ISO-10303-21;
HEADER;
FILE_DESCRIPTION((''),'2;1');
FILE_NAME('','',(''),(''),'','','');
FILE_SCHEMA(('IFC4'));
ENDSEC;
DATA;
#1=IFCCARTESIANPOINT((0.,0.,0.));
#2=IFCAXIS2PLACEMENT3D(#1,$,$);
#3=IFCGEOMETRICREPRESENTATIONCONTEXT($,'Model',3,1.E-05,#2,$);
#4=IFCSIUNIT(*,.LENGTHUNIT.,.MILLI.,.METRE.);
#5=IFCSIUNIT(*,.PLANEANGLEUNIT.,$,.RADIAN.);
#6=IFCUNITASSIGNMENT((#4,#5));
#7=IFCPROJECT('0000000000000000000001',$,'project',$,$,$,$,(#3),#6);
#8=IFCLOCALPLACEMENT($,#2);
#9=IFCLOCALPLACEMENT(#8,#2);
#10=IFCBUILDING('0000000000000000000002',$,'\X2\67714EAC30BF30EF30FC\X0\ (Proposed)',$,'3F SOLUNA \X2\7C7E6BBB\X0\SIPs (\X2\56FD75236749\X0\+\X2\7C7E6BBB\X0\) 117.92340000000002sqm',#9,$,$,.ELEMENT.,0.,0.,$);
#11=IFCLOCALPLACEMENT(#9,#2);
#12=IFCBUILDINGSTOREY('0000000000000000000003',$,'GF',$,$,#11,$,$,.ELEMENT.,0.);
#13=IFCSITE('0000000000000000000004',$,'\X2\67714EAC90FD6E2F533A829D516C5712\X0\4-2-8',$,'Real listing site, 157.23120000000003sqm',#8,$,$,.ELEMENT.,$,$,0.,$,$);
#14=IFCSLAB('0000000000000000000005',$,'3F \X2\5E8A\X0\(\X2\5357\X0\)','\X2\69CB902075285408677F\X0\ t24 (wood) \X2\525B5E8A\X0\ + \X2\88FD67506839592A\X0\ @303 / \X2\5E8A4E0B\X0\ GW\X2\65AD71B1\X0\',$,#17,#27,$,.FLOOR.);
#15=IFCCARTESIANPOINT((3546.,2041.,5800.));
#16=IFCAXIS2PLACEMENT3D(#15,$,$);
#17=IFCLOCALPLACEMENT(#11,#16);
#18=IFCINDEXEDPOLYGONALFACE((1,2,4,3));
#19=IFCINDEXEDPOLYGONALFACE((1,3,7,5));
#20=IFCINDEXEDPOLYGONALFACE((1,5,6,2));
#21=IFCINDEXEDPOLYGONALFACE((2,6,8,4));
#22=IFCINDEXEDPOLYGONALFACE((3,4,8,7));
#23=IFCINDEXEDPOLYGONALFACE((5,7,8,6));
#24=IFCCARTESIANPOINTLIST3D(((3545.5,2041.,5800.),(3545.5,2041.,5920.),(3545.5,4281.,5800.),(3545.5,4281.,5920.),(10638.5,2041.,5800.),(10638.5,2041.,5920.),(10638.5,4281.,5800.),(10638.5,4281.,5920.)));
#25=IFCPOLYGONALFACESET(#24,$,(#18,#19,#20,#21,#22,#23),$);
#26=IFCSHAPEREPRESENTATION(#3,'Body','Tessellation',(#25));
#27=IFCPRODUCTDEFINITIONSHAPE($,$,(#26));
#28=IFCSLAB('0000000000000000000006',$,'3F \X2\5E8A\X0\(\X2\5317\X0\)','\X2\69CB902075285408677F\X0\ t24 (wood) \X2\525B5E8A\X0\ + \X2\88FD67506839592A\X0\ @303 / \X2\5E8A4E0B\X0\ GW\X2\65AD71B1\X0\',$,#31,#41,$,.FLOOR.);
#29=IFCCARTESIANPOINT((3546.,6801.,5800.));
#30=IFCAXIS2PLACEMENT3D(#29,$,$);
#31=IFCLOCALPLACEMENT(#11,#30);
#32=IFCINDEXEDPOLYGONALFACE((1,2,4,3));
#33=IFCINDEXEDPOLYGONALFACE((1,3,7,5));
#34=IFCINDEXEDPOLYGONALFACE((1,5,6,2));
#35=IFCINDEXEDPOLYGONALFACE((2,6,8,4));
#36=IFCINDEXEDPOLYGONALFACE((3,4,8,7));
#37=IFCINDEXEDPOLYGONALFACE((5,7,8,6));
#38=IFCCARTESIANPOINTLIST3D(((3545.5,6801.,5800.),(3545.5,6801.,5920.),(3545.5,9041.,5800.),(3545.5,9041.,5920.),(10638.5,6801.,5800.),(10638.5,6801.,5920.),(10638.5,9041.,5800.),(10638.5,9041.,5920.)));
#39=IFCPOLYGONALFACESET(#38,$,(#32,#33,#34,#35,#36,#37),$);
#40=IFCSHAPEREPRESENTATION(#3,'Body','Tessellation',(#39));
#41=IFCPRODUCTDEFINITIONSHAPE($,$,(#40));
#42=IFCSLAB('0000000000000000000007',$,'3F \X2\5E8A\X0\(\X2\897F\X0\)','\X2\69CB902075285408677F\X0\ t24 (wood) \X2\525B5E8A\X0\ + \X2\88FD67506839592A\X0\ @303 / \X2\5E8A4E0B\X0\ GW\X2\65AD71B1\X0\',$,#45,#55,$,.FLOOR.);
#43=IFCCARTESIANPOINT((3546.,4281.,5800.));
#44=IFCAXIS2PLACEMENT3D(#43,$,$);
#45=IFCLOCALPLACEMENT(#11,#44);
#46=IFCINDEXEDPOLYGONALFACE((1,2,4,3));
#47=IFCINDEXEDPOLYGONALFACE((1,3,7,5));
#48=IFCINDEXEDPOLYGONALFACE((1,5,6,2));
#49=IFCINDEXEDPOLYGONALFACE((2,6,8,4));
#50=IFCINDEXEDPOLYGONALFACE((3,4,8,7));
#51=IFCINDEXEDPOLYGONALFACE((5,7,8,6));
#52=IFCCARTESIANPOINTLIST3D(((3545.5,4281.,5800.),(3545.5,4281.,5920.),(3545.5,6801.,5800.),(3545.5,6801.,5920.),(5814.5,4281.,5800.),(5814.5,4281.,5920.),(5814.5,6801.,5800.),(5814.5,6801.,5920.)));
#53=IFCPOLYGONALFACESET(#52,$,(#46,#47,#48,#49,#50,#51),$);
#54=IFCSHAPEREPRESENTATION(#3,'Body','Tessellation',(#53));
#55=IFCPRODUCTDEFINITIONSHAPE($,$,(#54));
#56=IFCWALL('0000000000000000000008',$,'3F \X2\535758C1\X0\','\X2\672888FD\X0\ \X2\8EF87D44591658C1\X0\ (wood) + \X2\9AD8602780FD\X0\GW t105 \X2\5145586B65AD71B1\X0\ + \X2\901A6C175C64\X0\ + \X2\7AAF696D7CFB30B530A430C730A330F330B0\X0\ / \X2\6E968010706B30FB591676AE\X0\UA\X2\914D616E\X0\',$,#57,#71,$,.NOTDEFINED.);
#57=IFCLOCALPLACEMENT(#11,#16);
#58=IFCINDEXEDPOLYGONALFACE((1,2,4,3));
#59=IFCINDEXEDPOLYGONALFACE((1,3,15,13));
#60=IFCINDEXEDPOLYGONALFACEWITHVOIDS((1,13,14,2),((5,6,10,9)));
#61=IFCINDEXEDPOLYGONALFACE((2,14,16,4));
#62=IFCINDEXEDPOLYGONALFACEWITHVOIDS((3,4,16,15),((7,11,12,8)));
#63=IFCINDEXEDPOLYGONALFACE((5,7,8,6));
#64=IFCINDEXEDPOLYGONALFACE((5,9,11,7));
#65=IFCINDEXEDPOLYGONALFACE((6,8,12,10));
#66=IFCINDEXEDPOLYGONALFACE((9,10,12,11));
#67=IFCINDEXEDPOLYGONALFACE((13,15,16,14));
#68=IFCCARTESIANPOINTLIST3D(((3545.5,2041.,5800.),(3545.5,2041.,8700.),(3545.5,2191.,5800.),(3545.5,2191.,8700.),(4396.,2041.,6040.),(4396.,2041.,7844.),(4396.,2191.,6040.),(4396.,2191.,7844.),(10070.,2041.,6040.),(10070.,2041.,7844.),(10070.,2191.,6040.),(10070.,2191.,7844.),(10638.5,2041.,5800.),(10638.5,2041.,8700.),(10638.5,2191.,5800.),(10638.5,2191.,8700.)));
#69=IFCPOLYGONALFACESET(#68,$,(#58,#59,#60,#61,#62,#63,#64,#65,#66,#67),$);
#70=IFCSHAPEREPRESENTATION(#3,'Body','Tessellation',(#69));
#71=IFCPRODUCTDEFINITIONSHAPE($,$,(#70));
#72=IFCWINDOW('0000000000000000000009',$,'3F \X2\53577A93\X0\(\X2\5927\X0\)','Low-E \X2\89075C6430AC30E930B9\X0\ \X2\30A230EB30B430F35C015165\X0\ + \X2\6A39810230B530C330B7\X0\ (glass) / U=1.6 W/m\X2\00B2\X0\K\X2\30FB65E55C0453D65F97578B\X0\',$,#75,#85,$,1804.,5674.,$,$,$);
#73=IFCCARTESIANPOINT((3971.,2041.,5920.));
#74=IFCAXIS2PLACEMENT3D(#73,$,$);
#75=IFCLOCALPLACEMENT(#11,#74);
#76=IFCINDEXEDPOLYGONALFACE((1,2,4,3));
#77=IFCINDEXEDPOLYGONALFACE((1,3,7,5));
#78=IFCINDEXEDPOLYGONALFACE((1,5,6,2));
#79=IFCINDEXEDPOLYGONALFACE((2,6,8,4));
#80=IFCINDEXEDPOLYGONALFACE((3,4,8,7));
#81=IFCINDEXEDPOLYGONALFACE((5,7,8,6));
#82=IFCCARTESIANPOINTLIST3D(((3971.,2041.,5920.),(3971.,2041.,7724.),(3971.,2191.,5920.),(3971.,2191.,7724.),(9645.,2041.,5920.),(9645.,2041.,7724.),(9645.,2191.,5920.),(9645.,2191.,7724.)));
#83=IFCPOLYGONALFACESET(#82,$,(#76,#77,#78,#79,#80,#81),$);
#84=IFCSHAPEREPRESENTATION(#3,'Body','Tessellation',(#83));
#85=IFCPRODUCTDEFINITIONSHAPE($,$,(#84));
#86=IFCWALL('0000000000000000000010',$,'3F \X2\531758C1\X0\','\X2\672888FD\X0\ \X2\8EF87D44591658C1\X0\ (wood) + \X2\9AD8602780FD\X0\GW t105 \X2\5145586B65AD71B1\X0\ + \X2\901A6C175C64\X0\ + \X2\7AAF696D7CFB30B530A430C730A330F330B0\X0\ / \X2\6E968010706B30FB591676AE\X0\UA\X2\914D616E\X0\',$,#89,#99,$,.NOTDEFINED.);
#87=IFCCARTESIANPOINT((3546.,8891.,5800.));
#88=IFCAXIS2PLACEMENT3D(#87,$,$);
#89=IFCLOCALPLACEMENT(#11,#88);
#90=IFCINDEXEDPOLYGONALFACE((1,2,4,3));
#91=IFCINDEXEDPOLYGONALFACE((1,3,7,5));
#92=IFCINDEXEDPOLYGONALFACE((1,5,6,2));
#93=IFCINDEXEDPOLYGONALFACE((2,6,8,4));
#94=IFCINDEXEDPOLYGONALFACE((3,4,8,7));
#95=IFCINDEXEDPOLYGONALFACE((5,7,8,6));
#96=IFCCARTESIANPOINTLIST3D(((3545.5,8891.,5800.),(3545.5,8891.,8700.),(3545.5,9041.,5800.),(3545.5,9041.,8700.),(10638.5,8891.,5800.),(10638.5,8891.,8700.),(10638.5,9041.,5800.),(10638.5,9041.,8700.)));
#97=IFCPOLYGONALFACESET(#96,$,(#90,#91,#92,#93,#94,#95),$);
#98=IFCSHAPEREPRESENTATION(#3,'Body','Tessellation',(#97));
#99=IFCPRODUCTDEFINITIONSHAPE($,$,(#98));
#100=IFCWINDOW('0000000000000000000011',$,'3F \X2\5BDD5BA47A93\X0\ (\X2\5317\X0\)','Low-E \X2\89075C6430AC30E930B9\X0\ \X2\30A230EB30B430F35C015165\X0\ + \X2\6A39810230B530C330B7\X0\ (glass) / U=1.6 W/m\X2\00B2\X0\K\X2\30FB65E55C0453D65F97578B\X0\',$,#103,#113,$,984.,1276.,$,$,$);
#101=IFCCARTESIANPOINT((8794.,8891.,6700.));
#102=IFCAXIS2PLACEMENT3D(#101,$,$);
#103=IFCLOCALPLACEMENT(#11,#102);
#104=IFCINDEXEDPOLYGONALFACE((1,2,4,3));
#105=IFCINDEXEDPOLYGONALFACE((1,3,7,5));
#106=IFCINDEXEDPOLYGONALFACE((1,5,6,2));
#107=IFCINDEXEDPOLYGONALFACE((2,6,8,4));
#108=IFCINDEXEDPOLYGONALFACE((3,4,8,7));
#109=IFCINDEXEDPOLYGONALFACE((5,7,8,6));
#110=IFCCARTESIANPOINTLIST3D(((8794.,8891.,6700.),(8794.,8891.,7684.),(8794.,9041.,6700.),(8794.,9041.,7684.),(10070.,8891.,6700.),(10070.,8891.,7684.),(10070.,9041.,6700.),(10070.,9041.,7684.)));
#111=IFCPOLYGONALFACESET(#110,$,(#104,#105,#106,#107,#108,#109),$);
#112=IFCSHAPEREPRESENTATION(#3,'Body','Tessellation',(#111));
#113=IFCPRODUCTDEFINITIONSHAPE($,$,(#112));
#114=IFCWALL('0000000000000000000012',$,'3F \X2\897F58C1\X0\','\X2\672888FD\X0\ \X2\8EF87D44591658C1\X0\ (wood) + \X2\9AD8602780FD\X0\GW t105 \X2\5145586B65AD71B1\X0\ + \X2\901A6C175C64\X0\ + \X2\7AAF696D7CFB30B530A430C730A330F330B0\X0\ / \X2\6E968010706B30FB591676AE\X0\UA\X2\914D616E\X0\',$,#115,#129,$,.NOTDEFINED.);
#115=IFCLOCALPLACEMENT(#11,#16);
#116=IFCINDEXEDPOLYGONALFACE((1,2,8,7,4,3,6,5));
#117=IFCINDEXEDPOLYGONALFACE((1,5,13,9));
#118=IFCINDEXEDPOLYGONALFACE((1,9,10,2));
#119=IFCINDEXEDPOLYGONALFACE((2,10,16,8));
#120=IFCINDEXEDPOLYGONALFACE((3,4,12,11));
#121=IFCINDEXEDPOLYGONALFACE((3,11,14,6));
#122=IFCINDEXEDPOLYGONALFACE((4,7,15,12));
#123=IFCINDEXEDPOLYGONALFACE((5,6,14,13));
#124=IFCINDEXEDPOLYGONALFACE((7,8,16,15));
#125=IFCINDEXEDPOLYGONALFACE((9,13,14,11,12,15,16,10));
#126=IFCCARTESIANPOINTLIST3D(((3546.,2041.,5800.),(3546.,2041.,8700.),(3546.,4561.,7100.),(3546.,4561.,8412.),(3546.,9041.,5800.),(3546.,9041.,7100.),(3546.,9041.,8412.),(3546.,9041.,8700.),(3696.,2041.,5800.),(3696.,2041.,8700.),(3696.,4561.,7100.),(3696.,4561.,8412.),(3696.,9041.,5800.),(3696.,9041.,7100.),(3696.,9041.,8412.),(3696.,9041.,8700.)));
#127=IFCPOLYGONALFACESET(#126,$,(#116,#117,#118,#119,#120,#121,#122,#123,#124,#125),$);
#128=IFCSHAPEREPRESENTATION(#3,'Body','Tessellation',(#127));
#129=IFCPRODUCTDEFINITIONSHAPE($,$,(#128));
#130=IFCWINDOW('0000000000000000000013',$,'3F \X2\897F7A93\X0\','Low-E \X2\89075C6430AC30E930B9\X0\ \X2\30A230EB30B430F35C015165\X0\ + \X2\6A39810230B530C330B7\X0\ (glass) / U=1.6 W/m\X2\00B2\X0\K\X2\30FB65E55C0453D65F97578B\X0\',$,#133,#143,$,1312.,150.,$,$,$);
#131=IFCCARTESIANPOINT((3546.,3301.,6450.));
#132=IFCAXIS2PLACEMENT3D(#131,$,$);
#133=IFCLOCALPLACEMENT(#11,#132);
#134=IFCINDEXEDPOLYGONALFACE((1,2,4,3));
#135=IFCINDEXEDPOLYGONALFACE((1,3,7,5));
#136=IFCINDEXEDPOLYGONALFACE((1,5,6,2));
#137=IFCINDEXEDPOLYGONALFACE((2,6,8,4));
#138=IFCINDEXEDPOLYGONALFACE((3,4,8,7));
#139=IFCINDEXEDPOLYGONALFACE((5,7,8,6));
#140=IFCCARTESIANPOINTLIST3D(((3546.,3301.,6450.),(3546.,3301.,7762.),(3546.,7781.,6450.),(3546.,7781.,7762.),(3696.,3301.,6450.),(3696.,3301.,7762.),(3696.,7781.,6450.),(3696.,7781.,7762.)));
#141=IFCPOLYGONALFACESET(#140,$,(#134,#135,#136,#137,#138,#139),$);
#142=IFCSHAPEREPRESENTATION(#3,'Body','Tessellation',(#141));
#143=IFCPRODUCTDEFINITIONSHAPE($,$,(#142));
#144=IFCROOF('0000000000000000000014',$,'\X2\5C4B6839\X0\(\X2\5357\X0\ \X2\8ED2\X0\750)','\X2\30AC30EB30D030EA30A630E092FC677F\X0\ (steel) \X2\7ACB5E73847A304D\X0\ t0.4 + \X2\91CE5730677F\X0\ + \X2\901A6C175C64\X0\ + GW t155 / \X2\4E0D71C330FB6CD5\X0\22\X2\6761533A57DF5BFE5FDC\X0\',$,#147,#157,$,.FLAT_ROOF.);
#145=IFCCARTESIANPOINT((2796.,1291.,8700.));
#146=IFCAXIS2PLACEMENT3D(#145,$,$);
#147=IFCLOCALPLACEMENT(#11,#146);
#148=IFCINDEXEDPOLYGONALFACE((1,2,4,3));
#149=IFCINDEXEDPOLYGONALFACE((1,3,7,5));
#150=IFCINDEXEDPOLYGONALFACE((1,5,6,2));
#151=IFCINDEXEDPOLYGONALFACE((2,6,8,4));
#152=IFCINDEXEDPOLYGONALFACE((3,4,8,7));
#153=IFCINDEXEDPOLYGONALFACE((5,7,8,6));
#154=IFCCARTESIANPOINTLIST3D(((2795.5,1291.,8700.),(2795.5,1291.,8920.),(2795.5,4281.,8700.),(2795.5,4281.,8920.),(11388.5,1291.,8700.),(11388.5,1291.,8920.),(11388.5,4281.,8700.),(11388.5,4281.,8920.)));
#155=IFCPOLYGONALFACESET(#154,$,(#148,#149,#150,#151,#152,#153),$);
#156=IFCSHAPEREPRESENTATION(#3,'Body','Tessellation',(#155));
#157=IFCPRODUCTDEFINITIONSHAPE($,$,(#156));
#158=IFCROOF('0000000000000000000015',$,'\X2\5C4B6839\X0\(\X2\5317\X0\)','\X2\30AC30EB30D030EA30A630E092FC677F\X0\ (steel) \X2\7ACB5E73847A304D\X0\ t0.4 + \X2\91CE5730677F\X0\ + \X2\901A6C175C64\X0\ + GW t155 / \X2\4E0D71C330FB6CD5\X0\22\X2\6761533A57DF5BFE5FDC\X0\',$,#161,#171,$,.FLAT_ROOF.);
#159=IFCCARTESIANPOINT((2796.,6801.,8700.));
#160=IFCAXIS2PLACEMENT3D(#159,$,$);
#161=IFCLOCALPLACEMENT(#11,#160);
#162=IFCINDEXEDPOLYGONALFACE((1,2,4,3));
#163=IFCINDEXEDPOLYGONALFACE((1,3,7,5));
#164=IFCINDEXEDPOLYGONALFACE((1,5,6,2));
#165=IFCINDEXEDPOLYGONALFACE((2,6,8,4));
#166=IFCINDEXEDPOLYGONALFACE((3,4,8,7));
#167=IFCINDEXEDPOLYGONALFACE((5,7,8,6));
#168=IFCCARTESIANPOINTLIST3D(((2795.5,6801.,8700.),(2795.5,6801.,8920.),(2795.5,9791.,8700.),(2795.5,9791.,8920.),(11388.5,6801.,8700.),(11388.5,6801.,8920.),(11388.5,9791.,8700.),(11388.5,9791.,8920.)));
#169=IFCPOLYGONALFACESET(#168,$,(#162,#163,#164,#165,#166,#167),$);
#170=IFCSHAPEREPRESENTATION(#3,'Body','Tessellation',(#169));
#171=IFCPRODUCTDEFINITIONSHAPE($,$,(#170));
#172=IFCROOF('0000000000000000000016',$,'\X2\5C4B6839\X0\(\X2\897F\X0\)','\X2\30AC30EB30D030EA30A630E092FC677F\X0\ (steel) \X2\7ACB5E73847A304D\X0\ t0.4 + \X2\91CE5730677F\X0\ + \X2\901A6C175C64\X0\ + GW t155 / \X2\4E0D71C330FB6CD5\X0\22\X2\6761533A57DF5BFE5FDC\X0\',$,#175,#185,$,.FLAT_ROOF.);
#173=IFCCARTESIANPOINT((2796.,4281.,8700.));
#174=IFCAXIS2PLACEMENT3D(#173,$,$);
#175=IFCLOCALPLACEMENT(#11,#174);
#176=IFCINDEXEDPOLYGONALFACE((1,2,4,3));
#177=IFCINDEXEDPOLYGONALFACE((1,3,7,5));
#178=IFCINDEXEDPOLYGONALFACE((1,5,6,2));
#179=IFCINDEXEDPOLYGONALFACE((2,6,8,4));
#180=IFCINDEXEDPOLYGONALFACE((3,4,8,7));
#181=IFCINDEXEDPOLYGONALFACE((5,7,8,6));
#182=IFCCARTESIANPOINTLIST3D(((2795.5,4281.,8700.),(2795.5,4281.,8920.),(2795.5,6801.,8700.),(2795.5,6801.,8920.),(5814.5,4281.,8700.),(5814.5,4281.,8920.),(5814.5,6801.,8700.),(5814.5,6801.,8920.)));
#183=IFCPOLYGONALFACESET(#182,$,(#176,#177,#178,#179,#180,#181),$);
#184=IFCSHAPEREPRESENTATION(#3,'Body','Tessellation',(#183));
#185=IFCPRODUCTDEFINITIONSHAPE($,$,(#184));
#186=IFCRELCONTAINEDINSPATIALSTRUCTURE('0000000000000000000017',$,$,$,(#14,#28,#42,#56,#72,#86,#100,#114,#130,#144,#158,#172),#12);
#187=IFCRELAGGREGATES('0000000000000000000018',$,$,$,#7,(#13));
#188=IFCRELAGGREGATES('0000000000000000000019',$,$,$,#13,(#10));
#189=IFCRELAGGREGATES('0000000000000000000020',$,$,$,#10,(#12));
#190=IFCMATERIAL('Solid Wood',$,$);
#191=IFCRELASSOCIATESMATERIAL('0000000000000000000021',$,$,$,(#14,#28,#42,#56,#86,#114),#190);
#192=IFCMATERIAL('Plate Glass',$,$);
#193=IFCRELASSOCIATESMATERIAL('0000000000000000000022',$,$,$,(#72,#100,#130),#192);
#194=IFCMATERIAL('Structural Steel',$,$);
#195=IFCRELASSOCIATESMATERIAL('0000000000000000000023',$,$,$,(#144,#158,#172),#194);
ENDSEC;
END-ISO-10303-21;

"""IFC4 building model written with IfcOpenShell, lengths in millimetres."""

from ifc_helpers import new_model, si_unit, frame, frame_2d, origin, place, context, project, spatial, rectangle, extrude, material, element, fill, save


model = new_model("IFC4")

# Units and contexts
model_context = context("Model", 3, precision=1e-05, world=origin())
ifc_project = project(units=[si_unit("LENGTHUNIT", "METRE", prefix="MILLI"), si_unit("PLANEANGLEUNIT", "RADIAN")], contexts=[model_context])

# Site, building, storey
site_placement = place(None, origin())
site = spatial("IfcSite", under=ifc_project, at=site_placement, Name="東京都港区芝公園4-2-8", ObjectType="Real listing site, 157.23120000000003sqm", CompositionType="ELEMENT", RefElevation=0.0)
building_placement = place(site_placement, origin())
building = spatial("IfcBuilding", under=site, at=building_placement, Name="東京タワー (Proposed)", ObjectType="3F SOLUNA 籾殻SIPs (国産杉+籾殻) 117.92340000000002sqm", CompositionType="ELEMENT", ElevationOfRefHeight=0.0, ElevationOfTerrain=0.0)
storey_placement = place(building_placement, origin())
storey = spatial("IfcBuildingStorey", under=building, at=storey_placement, Name="GF", CompositionType="ELEMENT", Elevation=0.0)

# Slabs
ifc_material_1 = material(Name="Solid Wood")
slab_1_placement = place(storey_placement, frame((3546.0, 2041.0, 5800.0)))
element("IfcSlab", 1, at=slab_1_placement, inside=storey, material=ifc_material_1, Name="3F 床(南)", Description="構造用合板 t24 (wood) 剛床 + 製材根太 @303 / 床下 GW断熱", PredefinedType="FLOOR", context=model_context, shape_type="SweptSolid", body=[
    extrude(rectangle(XDim=7093.0, YDim=2240.0, at=frame_2d((3546.0, 1120.0))), frame((3546.0, 2041.0, 5800.0)), (0.0, 0.0, 1.0), 120.0),
])
slab_2_placement = place(storey_placement, frame((3546.0, 6801.0, 5800.0)))
element("IfcSlab", 2, at=slab_2_placement, inside=storey, material=ifc_material_1, Name="3F 床(北)", Description="構造用合板 t24 (wood) 剛床 + 製材根太 @303 / 床下 GW断熱", PredefinedType="FLOOR", context=model_context, shape_type="SweptSolid", body=[
    extrude(rectangle(XDim=7093.0, YDim=2240.0, at=frame_2d((3546.0, 1120.0))), frame((3546.0, 6801.0, 5800.0)), (0.0, 0.0, 1.0), 120.0),
])
slab_3_placement = place(storey_placement, frame((3546.0, 4281.0, 5800.0)))
element("IfcSlab", 3, at=slab_3_placement, inside=storey, material=ifc_material_1, Name="3F 床(西)", Description="構造用合板 t24 (wood) 剛床 + 製材根太 @303 / 床下 GW断熱", PredefinedType="FLOOR", context=model_context, shape_type="SweptSolid", body=[
    extrude(rectangle(XDim=2269.0, YDim=2520.0, at=frame_2d((1134.0, 1260.0))), frame((3546.0, 4281.0, 5800.0)), (0.0, 0.0, 1.0), 120.0),
])

# Walls, openings, windows
wall_1_placement = place(storey_placement, frame((3546.0, 2041.0, 5800.0)))
wall_1 = element("IfcWall", 4, at=wall_1_placement, inside=storey, material=ifc_material_1, Name="3F 南壁", Description="木製 軸組外壁 (wood) + 高性能GW t105 充填断熱 + 通気層 + 窯業系サイディング / 準耐火・外皮UA配慮", PredefinedType="NOTDEFINED", context=model_context, shape_type="SweptSolid", body=[
    extrude(rectangle(XDim=7093.0, YDim=150.0, at=frame_2d((3546.0, 75.0))), frame((3546.0, 2041.0, 5800.0)), (0.0, 0.0, 1.0), 2900.0),
])
opening_1_placement = place(storey_placement, frame((3971.0, 2041.0, 5920.0)))
opening_1 = element("IfcOpeningElement", 5, at=opening_1_placement, cuts=wall_1, PredefinedType="NOTDEFINED", context=model_context, shape_type="SweptSolid", body=[
    extrude(rectangle(XDim=5674.0, YDim=150.0, at=frame_2d((2837.0, 75.0))), frame((3971.0, 2041.0, 5920.0)), (0.0, 0.0, 1.0), 1804.0),
])
ifc_material_2 = material(Name="Plate Glass")
window_1_placement = place(storey_placement, frame((3971.0, 2041.0, 5920.0)))
window_1 = element("IfcWindow", 6, at=window_1_placement, inside=storey, material=ifc_material_2, Name="3F 南窓(大)", Description="Low-E 複層ガラス アルゴン封入 + 樹脂サッシ (glass) / U=1.6 W/m²K・日射取得型", OverallHeight=1804.0, OverallWidth=5674.0, context=model_context, shape_type="SweptSolid", body=[
    extrude(rectangle(XDim=5674.0, YDim=150.0, at=frame_2d((2837.0, 75.0))), frame((3971.0, 2041.0, 5920.0)), (0.0, 0.0, 1.0), 1804.0),
])
fill(opening_1, window_1)
wall_2_placement = place(storey_placement, frame((3546.0, 8891.0, 5800.0)))
wall_2 = element("IfcWall", 7, at=wall_2_placement, inside=storey, material=ifc_material_1, Name="3F 北壁", Description="木製 軸組外壁 (wood) + 高性能GW t105 充填断熱 + 通気層 + 窯業系サイディング / 準耐火・外皮UA配慮", PredefinedType="NOTDEFINED", context=model_context, shape_type="SweptSolid", body=[
    extrude(rectangle(XDim=7093.0, YDim=150.0, at=frame_2d((3546.0, 75.0))), frame((3546.0, 8891.0, 5800.0)), (0.0, 0.0, 1.0), 2900.0),
])
opening_2_placement = place(storey_placement, frame((8794.0, 8891.0, 6700.0)))
opening_2 = element("IfcOpeningElement", 8, at=opening_2_placement, cuts=wall_2, PredefinedType="NOTDEFINED", context=model_context, shape_type="SweptSolid", body=[
    extrude(rectangle(XDim=1276.0, YDim=150.0, at=frame_2d((638.0, 75.0))), frame((8794.0, 8891.0, 6700.0)), (0.0, 0.0, 1.0), 984.0),
])
window_2_placement = place(storey_placement, frame((8794.0, 8891.0, 6700.0)))
window_2 = element("IfcWindow", 9, at=window_2_placement, inside=storey, material=ifc_material_2, Name="3F 寝室窓 (北)", Description="Low-E 複層ガラス アルゴン封入 + 樹脂サッシ (glass) / U=1.6 W/m²K・日射取得型", OverallHeight=984.0, OverallWidth=1276.0, context=model_context, shape_type="SweptSolid", body=[
    extrude(rectangle(XDim=1276.0, YDim=150.0, at=frame_2d((638.0, 75.0))), frame((8794.0, 8891.0, 6700.0)), (0.0, 0.0, 1.0), 984.0),
])
fill(opening_2, window_2)
wall_3_placement = place(storey_placement, frame((3546.0, 2041.0, 5800.0)))
wall_3 = element("IfcWall", 10, at=wall_3_placement, inside=storey, material=ifc_material_1, Name="3F 西壁", Description="木製 軸組外壁 (wood) + 高性能GW t105 充填断熱 + 通気層 + 窯業系サイディング / 準耐火・外皮UA配慮", PredefinedType="NOTDEFINED", context=model_context, shape_type="SweptSolid", body=[
    extrude(rectangle(XDim=150.0, YDim=7000.0, at=frame_2d((75.0, 3500.0))), frame((3546.0, 2041.0, 5800.0)), (0.0, 0.0, 1.0), 2900.0),
])
opening_3_placement = place(storey_placement, frame((3546.0, 3301.0, 6450.0)))
opening_3 = element("IfcOpeningElement", 11, at=opening_3_placement, cuts=wall_3, PredefinedType="NOTDEFINED", context=model_context, shape_type="SweptSolid", body=[
    extrude(rectangle(XDim=150.0, YDim=4480.0, at=frame_2d((75.0, 2240.0))), frame((3546.0, 3301.0, 6450.0)), (0.0, 0.0, 1.0), 1312.0),
])
window_3_placement = place(storey_placement, frame((3546.0, 3301.0, 6450.0)))
window_3 = element("IfcWindow", 12, at=window_3_placement, inside=storey, material=ifc_material_2, Name="3F 西窓", Description="Low-E 複層ガラス アルゴン封入 + 樹脂サッシ (glass) / U=1.6 W/m²K・日射取得型", OverallHeight=1312.0, OverallWidth=150.0, context=model_context, shape_type="SweptSolid", body=[
    extrude(rectangle(XDim=150.0, YDim=4480.0, at=frame_2d((75.0, 2240.0))), frame((3546.0, 3301.0, 6450.0)), (0.0, 0.0, 1.0), 1312.0),
])
fill(opening_3, window_3)

# Roofs
ifc_material_3 = material(Name="Structural Steel")
roof_1_placement = place(storey_placement, frame((2796.0, 1291.0, 8700.0)))
element("IfcRoof", 13, at=roof_1_placement, inside=storey, material=ifc_material_3, Name="屋根(南 軒750)", Description="ガルバリウム鋼板 (steel) 立平葺き t0.4 + 野地板 + 通気層 + GW t155 / 不燃・法22条区域対応", PredefinedType="FLAT_ROOF", context=model_context, shape_type="SweptSolid", body=[
    extrude(rectangle(XDim=8593.0, YDim=2990.0, at=frame_2d((4296.0, 1495.0))), frame((2796.0, 1291.0, 8700.0)), (0.0, 0.0, 1.0), 220.0),
])
roof_2_placement = place(storey_placement, frame((2796.0, 6801.0, 8700.0)))
element("IfcRoof", 14, at=roof_2_placement, inside=storey, material=ifc_material_3, Name="屋根(北)", Description="ガルバリウム鋼板 (steel) 立平葺き t0.4 + 野地板 + 通気層 + GW t155 / 不燃・法22条区域対応", PredefinedType="FLAT_ROOF", context=model_context, shape_type="SweptSolid", body=[
    extrude(rectangle(XDim=8593.0, YDim=2990.0, at=frame_2d((4296.0, 1495.0))), frame((2796.0, 6801.0, 8700.0)), (0.0, 0.0, 1.0), 220.0),
])
roof_3_placement = place(storey_placement, frame((2796.0, 4281.0, 8700.0)))
element("IfcRoof", 15, at=roof_3_placement, inside=storey, material=ifc_material_3, Name="屋根(西)", Description="ガルバリウム鋼板 (steel) 立平葺き t0.4 + 野地板 + 通気層 + GW t155 / 不燃・法22条区域対応", PredefinedType="FLAT_ROOF", context=model_context, shape_type="SweptSolid", body=[
    extrude(rectangle(XDim=3019.0, YDim=2520.0, at=frame_2d((1509.0, 1260.0))), frame((2796.0, 4281.0, 8700.0)), (0.0, 0.0, 1.0), 220.0),
])

save(model, "model.ifc")
